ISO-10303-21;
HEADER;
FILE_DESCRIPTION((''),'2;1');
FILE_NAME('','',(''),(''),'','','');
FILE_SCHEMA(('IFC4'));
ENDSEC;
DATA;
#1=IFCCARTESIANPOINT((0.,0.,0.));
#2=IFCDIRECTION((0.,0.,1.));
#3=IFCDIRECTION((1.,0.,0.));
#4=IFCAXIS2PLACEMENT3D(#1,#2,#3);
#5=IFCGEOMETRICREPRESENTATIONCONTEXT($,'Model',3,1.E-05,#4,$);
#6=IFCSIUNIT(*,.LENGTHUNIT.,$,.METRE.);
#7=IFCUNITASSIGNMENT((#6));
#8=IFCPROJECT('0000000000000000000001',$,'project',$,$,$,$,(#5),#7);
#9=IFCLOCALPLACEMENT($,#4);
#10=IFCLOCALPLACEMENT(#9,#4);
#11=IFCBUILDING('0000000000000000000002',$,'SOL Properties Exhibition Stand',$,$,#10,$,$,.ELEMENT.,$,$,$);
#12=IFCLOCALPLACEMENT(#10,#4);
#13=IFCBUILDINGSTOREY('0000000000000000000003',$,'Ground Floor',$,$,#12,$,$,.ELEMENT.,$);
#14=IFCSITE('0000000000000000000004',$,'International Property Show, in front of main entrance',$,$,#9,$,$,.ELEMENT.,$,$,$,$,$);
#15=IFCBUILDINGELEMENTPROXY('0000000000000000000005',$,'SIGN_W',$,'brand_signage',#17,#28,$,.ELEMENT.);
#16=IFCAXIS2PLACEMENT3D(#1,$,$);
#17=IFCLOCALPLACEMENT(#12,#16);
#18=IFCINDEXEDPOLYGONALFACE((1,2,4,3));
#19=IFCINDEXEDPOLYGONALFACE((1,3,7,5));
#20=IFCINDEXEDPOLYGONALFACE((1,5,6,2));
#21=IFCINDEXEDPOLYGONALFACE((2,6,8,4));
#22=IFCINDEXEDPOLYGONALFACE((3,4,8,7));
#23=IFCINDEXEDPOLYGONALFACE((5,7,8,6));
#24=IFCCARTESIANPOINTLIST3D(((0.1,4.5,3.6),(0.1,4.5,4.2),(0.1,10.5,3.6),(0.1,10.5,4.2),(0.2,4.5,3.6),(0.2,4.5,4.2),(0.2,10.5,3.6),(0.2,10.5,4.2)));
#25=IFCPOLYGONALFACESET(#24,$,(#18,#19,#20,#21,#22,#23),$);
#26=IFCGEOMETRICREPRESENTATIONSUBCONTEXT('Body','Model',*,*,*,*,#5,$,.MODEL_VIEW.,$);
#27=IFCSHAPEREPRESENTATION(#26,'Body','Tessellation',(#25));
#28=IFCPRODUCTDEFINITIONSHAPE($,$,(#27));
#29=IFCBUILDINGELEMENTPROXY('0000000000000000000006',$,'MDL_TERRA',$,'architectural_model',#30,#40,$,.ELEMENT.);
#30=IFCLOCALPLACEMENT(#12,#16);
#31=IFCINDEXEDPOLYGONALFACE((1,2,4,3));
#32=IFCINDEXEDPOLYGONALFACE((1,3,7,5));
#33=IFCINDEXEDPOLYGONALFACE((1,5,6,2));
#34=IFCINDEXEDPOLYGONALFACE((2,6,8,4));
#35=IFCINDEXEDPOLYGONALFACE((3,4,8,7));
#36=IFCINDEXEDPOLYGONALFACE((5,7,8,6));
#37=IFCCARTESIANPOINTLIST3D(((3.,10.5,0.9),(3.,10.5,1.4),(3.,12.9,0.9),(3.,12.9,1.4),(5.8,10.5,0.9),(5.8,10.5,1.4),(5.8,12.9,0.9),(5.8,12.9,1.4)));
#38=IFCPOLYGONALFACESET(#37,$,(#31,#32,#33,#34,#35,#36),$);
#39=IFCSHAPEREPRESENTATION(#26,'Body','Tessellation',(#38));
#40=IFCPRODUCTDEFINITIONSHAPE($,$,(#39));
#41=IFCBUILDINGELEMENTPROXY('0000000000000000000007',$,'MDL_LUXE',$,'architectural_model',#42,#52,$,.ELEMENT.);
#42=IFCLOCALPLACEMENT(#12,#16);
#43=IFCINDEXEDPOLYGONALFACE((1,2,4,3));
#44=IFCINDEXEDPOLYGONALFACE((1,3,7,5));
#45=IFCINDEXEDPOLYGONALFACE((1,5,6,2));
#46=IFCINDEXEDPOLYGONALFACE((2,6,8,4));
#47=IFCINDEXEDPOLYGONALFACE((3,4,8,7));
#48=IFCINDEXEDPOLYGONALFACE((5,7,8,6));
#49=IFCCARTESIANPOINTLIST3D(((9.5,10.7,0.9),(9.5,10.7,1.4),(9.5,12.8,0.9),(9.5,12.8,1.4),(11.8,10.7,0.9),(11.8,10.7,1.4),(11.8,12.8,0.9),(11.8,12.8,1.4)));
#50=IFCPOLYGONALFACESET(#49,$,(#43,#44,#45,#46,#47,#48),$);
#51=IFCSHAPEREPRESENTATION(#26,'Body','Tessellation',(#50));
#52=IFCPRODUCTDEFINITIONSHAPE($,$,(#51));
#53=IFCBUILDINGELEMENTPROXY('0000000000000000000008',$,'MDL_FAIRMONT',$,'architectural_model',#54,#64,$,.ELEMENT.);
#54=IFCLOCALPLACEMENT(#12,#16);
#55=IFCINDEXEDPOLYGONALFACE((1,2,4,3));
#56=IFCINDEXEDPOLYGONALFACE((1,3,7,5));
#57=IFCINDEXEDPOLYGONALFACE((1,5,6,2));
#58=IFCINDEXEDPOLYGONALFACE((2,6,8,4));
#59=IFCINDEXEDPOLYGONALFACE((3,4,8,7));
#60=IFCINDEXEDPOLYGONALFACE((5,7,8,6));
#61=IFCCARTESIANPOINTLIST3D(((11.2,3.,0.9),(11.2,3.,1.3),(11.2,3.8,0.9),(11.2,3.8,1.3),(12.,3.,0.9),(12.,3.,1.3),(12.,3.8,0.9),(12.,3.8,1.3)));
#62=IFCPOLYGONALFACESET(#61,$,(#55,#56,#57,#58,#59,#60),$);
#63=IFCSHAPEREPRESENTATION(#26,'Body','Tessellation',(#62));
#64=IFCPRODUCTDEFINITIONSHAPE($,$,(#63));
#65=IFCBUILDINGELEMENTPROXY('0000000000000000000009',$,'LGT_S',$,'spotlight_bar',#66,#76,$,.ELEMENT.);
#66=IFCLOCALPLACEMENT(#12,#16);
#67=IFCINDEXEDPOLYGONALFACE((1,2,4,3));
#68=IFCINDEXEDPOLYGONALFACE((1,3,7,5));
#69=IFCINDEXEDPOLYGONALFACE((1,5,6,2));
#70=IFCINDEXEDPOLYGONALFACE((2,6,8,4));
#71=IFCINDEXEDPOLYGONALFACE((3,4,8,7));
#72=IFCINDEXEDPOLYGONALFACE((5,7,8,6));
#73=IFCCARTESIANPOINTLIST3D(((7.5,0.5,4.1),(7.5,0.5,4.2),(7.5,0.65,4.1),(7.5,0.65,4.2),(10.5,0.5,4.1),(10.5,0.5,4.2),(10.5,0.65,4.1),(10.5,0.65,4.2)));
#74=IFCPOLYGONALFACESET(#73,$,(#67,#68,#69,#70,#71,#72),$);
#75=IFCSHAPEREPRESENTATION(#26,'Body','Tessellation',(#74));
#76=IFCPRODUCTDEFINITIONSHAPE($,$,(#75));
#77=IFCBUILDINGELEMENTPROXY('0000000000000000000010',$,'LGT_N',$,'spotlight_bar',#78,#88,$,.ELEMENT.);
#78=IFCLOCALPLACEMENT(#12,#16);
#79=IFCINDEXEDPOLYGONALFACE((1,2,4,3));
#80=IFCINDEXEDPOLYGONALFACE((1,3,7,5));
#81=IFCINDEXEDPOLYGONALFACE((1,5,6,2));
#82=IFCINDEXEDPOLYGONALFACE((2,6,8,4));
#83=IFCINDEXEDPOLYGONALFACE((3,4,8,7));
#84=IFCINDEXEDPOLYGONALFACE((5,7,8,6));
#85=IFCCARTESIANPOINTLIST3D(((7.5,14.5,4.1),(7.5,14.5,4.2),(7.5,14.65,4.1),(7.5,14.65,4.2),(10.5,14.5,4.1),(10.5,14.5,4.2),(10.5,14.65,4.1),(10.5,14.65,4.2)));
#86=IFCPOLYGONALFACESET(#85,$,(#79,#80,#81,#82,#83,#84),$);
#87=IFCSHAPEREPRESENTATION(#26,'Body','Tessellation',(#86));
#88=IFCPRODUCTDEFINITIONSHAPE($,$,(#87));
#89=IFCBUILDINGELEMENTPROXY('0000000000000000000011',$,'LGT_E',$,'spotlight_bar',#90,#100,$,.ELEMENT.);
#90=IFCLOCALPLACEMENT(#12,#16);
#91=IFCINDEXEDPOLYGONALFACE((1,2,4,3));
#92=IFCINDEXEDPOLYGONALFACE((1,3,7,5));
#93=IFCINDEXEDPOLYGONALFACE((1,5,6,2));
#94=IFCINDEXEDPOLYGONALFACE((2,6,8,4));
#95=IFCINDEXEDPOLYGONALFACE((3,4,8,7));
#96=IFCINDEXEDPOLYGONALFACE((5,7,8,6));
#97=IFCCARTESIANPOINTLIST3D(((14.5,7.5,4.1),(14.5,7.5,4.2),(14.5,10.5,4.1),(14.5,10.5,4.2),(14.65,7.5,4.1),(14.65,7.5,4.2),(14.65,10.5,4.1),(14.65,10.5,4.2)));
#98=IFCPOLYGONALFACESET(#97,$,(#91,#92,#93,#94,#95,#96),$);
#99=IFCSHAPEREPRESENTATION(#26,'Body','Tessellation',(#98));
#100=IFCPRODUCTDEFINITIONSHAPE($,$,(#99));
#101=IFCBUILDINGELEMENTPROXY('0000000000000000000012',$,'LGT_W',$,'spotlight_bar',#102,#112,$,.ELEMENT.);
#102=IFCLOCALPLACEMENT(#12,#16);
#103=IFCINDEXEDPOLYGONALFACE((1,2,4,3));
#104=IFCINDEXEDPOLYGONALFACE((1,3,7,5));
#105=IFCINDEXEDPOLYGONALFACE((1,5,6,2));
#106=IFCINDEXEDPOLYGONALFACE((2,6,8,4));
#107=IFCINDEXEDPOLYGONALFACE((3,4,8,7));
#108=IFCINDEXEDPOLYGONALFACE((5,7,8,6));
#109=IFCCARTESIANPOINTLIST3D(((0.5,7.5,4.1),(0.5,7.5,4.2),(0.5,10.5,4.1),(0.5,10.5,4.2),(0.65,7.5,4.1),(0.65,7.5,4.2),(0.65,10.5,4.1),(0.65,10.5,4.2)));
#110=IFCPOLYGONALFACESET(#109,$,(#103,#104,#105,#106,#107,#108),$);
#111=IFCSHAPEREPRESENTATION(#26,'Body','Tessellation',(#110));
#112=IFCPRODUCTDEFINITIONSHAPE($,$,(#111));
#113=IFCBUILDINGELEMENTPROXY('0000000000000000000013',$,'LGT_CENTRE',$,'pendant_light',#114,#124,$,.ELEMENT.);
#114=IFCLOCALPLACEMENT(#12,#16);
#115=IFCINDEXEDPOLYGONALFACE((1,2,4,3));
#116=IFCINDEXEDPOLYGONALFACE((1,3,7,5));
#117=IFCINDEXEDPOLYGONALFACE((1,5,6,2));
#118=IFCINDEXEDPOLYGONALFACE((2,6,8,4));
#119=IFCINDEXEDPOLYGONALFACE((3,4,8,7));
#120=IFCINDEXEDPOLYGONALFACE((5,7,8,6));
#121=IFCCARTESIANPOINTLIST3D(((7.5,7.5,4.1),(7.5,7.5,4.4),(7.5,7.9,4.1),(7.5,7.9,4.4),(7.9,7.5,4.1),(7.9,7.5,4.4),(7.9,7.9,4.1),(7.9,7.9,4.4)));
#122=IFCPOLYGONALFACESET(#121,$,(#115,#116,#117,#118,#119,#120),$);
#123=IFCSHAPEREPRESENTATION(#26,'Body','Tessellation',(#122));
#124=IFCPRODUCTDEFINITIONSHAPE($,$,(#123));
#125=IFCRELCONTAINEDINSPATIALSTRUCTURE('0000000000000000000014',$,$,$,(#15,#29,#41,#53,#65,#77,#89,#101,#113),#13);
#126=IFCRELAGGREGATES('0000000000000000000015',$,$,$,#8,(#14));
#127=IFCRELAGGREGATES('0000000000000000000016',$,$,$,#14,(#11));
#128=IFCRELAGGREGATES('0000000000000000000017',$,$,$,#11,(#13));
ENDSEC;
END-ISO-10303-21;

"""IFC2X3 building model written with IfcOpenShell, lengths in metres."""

from ifc_helpers import new_model, si_unit, frame, frame_2d, origin, origin_with_axes, place, context, subcontext, project, spatial, rectangle, extrude, element, save


model = new_model("IFC2X3")

# Units and contexts
model_context = context("Model", 3, precision=1e-05, world=origin_with_axes())
body_context = subcontext(model_context, "Body", "Model", "MODEL_VIEW")
ifc_project = project(units=[si_unit("LENGTHUNIT", "METRE")], contexts=[model_context])

# Site, building, storey
site_placement = place(None, origin_with_axes())
site = spatial("IfcSite", under=ifc_project, at=site_placement, Name="International Property Show, in front of main entrance", CompositionType="ELEMENT")
building_placement = place(site_placement, origin_with_axes())
building = spatial("IfcBuilding", under=site, at=building_placement, Name="SOL Properties Exhibition Stand", CompositionType="ELEMENT")
storey_placement = place(building_placement, origin_with_axes())
storey = spatial("IfcBuildingStorey", under=building, at=storey_placement, Name="Ground Floor", CompositionType="ELEMENT")

# Building element proxies
for number, where, z_axis, x_axis, name in (
    (1, (0.1, 4.5, 3.6), (0.0, 0.0, 1.0), (1.0, 0.0, 0.0), "SIGN_W"),
):
    element("IfcBuildingElementProxy", number, at=place(storey_placement, frame(where, z_axis=z_axis, x_axis=x_axis)), inside=storey, Name=name, ObjectType="brand_signage", CompositionType="ELEMENT", context=body_context, shape_type="SweptSolid", body=[
        extrude(rectangle(XDim=0.1, YDim=6.0, at=frame_2d((0.05, 3.0))), origin(), (0.0, 0.0, 1.0), 0.6),
    ])
proxy_1_placement = place(storey_placement, frame((3.0, 10.5, 0.9), z_axis=(0.0, 0.0, 1.0), x_axis=(1.0, 0.0, 0.0)))
element("IfcBuildingElementProxy", 2, at=proxy_1_placement, inside=storey, Name="MDL_TERRA", ObjectType="architectural_model", CompositionType="ELEMENT", context=body_context, shape_type="SweptSolid", body=[
    extrude(rectangle(XDim=2.8, YDim=2.4, at=frame_2d((1.4, 1.2))), origin(), (0.0, 0.0, 1.0), 0.5),
])
proxy_2_placement = place(storey_placement, frame((9.5, 10.7, 0.9), z_axis=(0.0, 0.0, 1.0), x_axis=(1.0, 0.0, 0.0)))
element("IfcBuildingElementProxy", 3, at=proxy_2_placement, inside=storey, Name="MDL_LUXE", ObjectType="architectural_model", CompositionType="ELEMENT", context=body_context, shape_type="SweptSolid", body=[
    extrude(rectangle(XDim=2.3, YDim=2.1, at=frame_2d((1.15, 1.05))), origin(), (0.0, 0.0, 1.0), 0.5),
])
proxy_3_placement = place(storey_placement, frame((11.2, 3.0, 0.9), z_axis=(0.0, 0.0, 1.0), x_axis=(1.0, 0.0, 0.0)))
element("IfcBuildingElementProxy", 4, at=proxy_3_placement, inside=storey, Name="MDL_FAIRMONT", ObjectType="architectural_model", CompositionType="ELEMENT", context=body_context, shape_type="SweptSolid", body=[
    extrude(rectangle(XDim=0.8, YDim=0.8, at=frame_2d((0.4, 0.4))), origin(), (0.0, 0.0, 1.0), 0.4),
])
for number, where, z_axis, x_axis, name in (
    (5, (7.5, 0.5, 4.1), (0.0, 0.0, 1.0), (1.0, 0.0, 0.0), "LGT_S"),
    (6, (7.5, 14.5, 4.1), (0.0, 0.0, 1.0), (1.0, 0.0, 0.0), "LGT_N"),
):
    element("IfcBuildingElementProxy", number, at=place(storey_placement, frame(where, z_axis=z_axis, x_axis=x_axis)), inside=storey, Name=name, ObjectType="spotlight_bar", CompositionType="ELEMENT", context=body_context, shape_type="SweptSolid", body=[
        extrude(rectangle(XDim=3.0, YDim=0.15, at=frame_2d((1.5, 0.075))), origin(), (0.0, 0.0, 1.0), 0.1),
    ])
for number, where, z_axis, x_axis, name in (
    (7, (14.5, 7.5, 4.1), (0.0, 0.0, 1.0), (1.0, 0.0, 0.0), "LGT_E"),
    (8, (0.5, 7.5, 4.1), (0.0, 0.0, 1.0), (1.0, 0.0, 0.0), "LGT_W"),
):
    element("IfcBuildingElementProxy", number, at=place(storey_placement, frame(where, z_axis=z_axis, x_axis=x_axis)), inside=storey, Name=name, ObjectType="spotlight_bar", CompositionType="ELEMENT", context=body_context, shape_type="SweptSolid", body=[
        extrude(rectangle(XDim=0.15, YDim=3.0, at=frame_2d((0.075, 1.5))), origin(), (0.0, 0.0, 1.0), 0.1),
    ])
proxy_4_placement = place(storey_placement, frame((7.5, 7.5, 4.1), z_axis=(0.0, 0.0, 1.0), x_axis=(1.0, 0.0, 0.0)))
element("IfcBuildingElementProxy", 9, at=proxy_4_placement, inside=storey, Name="LGT_CENTRE", ObjectType="pendant_light", CompositionType="ELEMENT", context=body_context, shape_type="SweptSolid", body=[
    extrude(rectangle(XDim=0.4, YDim=0.4, at=frame_2d((0.2, 0.2))), origin(), (0.0, 0.0, 1.0), 0.3),
])

save(model, "model.ifc")
